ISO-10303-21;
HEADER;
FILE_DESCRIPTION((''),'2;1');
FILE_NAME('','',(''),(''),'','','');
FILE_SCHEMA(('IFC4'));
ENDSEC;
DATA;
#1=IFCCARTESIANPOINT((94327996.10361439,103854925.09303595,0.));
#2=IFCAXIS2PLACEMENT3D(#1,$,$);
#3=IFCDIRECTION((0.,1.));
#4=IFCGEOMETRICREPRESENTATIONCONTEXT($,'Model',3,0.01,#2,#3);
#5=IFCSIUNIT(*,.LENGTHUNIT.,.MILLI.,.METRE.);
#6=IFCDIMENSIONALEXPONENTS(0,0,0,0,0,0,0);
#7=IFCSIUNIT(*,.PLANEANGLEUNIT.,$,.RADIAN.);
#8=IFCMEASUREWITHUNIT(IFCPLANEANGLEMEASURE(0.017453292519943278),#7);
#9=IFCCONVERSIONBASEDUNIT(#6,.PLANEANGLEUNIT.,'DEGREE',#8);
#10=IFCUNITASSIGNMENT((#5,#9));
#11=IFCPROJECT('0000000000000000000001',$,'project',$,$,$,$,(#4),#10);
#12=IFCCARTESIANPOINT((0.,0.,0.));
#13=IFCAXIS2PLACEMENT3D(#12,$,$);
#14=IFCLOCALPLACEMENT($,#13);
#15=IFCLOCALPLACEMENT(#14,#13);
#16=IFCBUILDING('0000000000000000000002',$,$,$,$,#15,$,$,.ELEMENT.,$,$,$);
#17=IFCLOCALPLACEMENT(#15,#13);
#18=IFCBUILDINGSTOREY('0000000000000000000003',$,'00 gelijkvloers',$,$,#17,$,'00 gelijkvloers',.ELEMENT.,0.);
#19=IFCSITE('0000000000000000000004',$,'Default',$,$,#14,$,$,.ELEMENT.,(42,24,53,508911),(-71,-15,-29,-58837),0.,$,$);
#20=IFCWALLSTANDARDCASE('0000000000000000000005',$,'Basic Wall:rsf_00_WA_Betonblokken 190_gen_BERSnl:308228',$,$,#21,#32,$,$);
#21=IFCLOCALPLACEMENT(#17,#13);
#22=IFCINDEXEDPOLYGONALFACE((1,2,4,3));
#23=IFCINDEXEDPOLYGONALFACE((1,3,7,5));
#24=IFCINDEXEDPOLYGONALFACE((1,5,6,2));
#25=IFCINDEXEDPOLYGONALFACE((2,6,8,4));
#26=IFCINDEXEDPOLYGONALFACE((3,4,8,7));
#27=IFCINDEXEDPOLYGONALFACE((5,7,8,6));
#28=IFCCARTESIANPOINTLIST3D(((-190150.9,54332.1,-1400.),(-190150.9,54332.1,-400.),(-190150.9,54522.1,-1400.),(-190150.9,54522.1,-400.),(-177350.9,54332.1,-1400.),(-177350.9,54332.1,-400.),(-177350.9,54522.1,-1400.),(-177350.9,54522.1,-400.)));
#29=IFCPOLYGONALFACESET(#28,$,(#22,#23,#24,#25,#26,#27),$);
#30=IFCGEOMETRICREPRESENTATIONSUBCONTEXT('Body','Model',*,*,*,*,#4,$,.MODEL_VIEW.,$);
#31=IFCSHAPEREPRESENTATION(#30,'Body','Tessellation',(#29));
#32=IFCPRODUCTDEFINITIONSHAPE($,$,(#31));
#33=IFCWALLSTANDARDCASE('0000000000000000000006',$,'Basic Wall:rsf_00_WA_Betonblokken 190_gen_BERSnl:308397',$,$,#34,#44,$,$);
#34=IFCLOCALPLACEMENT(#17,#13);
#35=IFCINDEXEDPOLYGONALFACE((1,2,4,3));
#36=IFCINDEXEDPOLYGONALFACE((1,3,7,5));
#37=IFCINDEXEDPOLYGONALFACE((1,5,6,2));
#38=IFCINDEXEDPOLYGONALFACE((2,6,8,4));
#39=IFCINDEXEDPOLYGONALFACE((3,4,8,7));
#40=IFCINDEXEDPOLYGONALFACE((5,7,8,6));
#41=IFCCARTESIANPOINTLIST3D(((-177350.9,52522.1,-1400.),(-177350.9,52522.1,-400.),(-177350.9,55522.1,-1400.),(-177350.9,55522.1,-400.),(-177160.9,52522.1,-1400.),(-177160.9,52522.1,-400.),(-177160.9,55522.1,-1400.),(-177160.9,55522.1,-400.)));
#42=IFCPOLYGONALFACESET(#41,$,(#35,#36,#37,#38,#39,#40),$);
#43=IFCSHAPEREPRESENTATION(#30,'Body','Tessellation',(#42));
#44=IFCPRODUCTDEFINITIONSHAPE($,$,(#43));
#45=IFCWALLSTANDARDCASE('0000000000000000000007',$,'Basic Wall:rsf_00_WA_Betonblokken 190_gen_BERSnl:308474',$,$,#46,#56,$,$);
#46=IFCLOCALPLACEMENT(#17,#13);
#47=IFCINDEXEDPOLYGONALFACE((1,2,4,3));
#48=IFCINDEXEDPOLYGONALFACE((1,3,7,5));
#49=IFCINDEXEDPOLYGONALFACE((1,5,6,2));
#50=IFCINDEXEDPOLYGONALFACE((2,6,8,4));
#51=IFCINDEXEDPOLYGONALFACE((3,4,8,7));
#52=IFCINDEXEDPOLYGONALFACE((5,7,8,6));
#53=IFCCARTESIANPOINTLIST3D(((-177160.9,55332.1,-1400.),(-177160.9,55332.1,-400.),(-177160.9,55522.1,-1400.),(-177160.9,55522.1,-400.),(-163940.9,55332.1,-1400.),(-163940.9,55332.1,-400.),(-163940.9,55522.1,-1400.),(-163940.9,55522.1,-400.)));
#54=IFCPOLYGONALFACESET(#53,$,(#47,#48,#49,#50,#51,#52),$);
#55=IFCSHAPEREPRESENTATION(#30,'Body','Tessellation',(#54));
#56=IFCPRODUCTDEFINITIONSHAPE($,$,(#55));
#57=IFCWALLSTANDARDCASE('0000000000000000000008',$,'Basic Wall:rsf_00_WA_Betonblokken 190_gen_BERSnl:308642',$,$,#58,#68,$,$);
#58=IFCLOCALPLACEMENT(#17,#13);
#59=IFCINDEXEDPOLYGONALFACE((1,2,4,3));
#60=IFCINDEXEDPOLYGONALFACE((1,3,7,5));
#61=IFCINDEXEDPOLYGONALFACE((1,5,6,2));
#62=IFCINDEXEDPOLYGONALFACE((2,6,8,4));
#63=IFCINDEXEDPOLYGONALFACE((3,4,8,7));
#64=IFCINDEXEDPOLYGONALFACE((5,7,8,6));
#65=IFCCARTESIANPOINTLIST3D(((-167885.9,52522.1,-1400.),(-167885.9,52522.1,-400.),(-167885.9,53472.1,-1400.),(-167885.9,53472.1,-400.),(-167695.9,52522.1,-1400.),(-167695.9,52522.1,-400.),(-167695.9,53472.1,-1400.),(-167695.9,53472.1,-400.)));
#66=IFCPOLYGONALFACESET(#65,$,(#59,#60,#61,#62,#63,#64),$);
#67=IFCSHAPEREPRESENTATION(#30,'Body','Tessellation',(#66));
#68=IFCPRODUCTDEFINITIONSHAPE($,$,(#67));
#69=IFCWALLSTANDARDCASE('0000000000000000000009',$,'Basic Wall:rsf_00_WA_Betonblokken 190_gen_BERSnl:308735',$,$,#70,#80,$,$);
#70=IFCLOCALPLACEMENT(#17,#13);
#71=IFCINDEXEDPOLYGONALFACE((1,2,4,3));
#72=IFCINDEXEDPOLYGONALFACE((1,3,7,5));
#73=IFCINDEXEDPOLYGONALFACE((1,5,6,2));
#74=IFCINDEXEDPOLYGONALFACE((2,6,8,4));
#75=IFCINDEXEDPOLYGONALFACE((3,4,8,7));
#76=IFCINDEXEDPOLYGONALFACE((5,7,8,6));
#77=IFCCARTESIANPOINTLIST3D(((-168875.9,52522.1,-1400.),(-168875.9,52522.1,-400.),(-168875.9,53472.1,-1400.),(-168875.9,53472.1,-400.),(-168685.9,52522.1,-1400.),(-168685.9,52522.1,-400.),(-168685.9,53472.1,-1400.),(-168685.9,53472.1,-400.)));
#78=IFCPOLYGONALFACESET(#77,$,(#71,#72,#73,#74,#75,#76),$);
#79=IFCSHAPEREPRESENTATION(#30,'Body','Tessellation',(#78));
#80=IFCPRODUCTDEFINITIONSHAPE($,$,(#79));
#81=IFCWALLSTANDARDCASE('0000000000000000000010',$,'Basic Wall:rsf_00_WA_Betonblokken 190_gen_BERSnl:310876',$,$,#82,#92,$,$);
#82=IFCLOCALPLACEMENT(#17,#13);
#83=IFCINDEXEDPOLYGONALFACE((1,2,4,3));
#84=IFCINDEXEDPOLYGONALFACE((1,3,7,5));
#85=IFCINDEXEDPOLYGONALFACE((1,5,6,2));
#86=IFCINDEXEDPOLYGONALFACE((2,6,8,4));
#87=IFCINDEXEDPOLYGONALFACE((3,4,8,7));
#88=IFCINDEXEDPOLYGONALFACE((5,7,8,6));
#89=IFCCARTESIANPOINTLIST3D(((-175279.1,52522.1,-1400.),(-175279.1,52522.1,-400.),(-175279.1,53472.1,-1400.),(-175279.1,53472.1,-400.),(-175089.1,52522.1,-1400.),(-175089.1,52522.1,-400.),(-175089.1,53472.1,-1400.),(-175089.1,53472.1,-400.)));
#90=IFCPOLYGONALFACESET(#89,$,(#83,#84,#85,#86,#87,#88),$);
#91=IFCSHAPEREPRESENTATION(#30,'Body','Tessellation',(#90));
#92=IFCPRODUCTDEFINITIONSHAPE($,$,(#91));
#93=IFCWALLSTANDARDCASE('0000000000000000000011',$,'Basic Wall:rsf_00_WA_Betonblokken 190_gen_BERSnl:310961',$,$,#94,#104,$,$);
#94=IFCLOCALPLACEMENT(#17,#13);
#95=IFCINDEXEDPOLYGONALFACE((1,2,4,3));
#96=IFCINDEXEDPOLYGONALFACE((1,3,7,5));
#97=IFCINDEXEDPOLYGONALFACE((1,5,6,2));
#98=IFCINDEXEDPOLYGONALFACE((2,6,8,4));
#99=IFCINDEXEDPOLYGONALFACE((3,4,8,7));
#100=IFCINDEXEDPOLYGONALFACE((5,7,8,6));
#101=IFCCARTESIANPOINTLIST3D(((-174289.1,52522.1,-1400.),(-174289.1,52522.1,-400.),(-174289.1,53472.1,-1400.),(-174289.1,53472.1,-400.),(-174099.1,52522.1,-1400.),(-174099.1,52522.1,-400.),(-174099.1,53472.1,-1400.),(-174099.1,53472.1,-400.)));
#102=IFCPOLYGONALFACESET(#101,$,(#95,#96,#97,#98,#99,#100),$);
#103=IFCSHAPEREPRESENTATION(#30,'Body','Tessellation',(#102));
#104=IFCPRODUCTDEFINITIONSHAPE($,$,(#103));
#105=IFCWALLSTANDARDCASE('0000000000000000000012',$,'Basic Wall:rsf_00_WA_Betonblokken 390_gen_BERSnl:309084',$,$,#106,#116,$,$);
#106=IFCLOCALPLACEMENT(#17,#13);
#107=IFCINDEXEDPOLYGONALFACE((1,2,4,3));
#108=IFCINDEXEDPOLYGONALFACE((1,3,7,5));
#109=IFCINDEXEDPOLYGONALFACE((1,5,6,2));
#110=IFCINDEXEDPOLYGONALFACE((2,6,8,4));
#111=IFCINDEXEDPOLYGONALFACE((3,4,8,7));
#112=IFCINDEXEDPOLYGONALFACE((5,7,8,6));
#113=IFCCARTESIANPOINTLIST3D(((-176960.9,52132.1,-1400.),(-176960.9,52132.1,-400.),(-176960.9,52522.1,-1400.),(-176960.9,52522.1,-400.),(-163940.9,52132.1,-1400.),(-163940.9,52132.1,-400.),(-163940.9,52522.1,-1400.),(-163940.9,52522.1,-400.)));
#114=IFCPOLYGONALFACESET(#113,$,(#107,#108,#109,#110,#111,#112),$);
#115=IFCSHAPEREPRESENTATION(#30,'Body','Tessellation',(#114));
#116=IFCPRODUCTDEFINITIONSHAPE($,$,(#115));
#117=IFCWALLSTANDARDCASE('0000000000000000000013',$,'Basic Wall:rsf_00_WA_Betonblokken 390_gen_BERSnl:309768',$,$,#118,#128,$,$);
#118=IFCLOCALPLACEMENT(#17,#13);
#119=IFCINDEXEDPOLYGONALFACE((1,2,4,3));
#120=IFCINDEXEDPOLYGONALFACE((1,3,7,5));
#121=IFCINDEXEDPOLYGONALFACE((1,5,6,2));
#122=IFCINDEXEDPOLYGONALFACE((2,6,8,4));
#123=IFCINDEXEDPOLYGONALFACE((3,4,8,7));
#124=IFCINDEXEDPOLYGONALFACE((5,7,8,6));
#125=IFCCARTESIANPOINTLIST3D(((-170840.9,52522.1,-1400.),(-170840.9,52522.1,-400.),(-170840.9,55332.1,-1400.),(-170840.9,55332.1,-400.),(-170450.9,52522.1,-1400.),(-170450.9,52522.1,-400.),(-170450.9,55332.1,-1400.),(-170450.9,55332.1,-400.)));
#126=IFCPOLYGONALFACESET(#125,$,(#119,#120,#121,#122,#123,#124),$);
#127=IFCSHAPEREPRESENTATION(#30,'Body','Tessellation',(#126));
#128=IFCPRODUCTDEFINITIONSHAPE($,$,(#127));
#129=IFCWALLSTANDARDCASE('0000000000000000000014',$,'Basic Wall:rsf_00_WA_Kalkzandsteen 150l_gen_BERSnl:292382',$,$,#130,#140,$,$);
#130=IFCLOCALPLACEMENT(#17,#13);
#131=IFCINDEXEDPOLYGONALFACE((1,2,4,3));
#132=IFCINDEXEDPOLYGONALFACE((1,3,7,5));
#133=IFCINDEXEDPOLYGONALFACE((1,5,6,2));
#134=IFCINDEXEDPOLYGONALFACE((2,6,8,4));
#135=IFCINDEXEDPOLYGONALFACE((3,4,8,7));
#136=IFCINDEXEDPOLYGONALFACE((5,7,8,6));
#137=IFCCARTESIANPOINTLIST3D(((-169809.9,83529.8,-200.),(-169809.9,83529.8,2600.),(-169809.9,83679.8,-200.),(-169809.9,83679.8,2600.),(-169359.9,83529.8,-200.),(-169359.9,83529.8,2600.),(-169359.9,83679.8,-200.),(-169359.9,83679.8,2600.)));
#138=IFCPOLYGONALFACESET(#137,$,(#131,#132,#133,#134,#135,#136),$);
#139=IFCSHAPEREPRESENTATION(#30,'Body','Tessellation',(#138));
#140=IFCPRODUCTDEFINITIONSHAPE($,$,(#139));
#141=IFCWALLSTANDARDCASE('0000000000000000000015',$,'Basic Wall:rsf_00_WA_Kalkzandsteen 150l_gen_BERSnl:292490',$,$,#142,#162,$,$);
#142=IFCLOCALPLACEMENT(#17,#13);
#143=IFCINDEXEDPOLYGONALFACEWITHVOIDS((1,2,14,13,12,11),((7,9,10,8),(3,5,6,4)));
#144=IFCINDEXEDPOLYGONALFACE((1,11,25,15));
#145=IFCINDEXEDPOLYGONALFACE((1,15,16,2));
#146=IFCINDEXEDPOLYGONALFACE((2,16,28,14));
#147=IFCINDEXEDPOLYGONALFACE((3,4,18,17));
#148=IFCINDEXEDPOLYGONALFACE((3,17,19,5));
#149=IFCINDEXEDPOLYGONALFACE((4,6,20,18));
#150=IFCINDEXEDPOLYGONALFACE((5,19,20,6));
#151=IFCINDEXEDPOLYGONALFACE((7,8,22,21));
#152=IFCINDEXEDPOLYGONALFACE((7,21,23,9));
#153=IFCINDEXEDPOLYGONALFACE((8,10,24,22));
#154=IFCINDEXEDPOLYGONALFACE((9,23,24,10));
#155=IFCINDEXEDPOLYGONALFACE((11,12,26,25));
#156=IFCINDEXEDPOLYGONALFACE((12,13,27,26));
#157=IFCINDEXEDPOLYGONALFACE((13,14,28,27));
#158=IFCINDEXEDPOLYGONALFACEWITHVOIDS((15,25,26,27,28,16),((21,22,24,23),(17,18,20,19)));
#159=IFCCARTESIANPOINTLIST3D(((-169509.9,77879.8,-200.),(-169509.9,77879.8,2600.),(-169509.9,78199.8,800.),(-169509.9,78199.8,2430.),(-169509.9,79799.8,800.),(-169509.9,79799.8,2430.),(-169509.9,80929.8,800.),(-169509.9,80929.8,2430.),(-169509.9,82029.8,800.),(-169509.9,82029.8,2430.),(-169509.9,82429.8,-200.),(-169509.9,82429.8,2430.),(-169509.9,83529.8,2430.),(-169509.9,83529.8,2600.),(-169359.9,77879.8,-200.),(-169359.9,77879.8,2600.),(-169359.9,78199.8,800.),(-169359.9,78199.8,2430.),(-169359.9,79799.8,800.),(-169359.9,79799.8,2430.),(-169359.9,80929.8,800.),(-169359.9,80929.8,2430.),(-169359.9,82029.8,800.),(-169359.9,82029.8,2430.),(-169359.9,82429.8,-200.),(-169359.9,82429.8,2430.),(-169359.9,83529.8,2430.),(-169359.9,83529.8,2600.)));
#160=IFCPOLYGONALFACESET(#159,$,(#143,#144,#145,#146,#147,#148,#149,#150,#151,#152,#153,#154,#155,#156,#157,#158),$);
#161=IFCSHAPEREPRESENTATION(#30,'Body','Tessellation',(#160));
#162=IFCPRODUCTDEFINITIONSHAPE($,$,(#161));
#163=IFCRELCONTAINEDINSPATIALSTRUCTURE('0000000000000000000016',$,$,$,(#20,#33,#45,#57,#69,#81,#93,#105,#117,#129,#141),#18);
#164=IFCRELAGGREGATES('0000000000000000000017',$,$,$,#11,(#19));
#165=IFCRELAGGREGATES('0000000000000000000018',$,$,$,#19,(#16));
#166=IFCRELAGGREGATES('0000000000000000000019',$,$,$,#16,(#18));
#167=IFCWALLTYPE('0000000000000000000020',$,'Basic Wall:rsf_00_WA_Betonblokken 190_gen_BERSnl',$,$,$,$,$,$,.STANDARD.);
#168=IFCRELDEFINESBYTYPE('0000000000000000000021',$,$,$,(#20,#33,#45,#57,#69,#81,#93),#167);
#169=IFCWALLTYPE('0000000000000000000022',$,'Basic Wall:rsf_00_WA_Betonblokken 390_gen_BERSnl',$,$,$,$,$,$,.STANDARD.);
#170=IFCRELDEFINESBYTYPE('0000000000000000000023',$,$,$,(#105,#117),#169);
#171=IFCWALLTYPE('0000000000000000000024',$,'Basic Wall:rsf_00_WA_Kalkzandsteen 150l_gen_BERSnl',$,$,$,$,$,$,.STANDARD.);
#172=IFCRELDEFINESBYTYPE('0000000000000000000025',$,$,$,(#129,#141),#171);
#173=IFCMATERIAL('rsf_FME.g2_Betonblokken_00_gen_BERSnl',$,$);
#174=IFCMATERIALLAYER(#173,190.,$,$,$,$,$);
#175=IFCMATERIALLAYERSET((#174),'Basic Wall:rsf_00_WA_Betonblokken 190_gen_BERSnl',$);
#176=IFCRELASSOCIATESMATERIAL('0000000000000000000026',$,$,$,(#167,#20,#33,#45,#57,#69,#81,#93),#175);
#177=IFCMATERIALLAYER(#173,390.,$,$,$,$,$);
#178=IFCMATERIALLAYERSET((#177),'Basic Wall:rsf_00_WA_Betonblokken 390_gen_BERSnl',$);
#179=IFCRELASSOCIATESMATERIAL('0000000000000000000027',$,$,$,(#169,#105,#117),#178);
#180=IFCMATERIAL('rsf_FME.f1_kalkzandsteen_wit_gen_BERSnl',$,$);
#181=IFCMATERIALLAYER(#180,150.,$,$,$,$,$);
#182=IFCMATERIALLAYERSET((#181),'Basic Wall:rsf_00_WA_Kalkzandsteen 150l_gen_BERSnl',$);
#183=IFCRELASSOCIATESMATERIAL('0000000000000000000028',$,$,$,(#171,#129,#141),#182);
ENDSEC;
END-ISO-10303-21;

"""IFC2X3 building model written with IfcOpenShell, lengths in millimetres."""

from ifc_helpers import new_model, entity, si_unit, converted_unit, direction, frame, frame_2d, origin, place, context, subcontext, project, spatial, polyline, rectangle, extrude, clip, bounded_halfspace, material, layer, layer_set, layer_usage, type_object, element, save


model = new_model("IFC2X3")

# Units and contexts
model_context = context("Model", 3, precision=0.01, world=frame((94327996.10361439, 103854925.09303595, 0.0)), true_north=direction((0.0, 1.0)))
body_context = subcontext(model_context, "Body", "Model", "MODEL_VIEW")
ifc_project = project(units=[si_unit("LENGTHUNIT", "METRE", prefix="MILLI"), converted_unit("PLANEANGLEUNIT", "DEGREE", entity("IfcPlaneAngleMeasure", 0.017453292519943278), si_unit("PLANEANGLEUNIT", "RADIAN"), dimensions=[0, 0, 0, 0, 0, 0, 0])], contexts=[model_context])

# Site, building, storey
site_placement = place(None, origin())
site = spatial("IfcSite", under=ifc_project, at=site_placement, Name="Default", CompositionType="ELEMENT", RefLatitude=(42, 24, 53, 508911), RefLongitude=(-71, -15, -29, -58837), RefElevation=0.0)
building_placement = place(site_placement, origin())
building = spatial("IfcBuilding", under=site, at=building_placement, CompositionType="ELEMENT")
storey_placement = place(building_placement, origin())
storey = spatial("IfcBuildingStorey", under=building, at=storey_placement, Name="00 gelijkvloers", LongName="00 gelijkvloers", CompositionType="ELEMENT", Elevation=0.0)

# Walls
ifc_material_1 = material(Name="rsf_FME.g2_Betonblokken_00_gen_BERSnl")
ifc_layer_1 = layer(ifc_material_1, 190.0)
ifc_layer_set_1 = layer_set([ifc_layer_1], Name="Basic Wall:rsf_00_WA_Betonblokken 190_gen_BERSnl")
ifc_layer_usage_1 = layer_usage(ifc_layer_set_1, "AXIS2", "NEGATIVE", 95.0)
wall_type_1 = type_object("IfcWallType", Name="Basic Wall:rsf_00_WA_Betonblokken 190_gen_BERSnl", PredefinedType="STANDARD", material=ifc_layer_set_1)
wall_1_placement = place(storey_placement, frame((-190150.9, 54427.1, -1400.0)))
element("IfcWallStandardCase", 1, at=wall_1_placement, inside=storey, type_object=wall_type_1, material=ifc_layer_usage_1, Name="Basic Wall:rsf_00_WA_Betonblokken 190_gen_BERSnl:308228", context=body_context, shape_type="SweptSolid", body=[
    extrude(rectangle(XDim=12800.0, YDim=190.0, at=frame_2d((6400.0, 0.0), x_axis=(-1.0, 0.0))), origin(), (0.0, 0.0, 1.0), 1000.0),
])
ifc_layer_usage_2 = layer_usage(ifc_layer_set_1, "AXIS2", "POSITIVE", -95.0)
wall_2_placement = place(storey_placement, frame((-177255.9, 52522.1, -1400.0), z_axis=(0.0, 0.0, 1.0), x_axis=(0.0, 1.0, 0.0)))
element("IfcWallStandardCase", 2, at=wall_2_placement, inside=storey, type_object=wall_type_1, material=ifc_layer_usage_2, Name="Basic Wall:rsf_00_WA_Betonblokken 190_gen_BERSnl:308397", context=body_context, shape_type="SweptSolid", body=[
    extrude(rectangle(XDim=3000.0, YDim=190.0, at=frame_2d((1500.0, 0.0), x_axis=(-1.0, 0.0))), origin(), (0.0, 0.0, 1.0), 1000.0),
])
ifc_layer_usage_3 = layer_usage(ifc_layer_set_1, "AXIS2", "POSITIVE", -95.0)
wall_3_placement = place(storey_placement, frame((-177160.9, 55427.1, -1400.0)))
element("IfcWallStandardCase", 3, at=wall_3_placement, inside=storey, type_object=wall_type_1, material=ifc_layer_usage_3, Name="Basic Wall:rsf_00_WA_Betonblokken 190_gen_BERSnl:308474", context=body_context, shape_type="SweptSolid", body=[
    extrude(rectangle(XDim=13220.0, YDim=190.0, at=frame_2d((6610.0, 0.0), x_axis=(-1.0, 0.0))), origin(), (0.0, 0.0, 1.0), 1000.0),
])
ifc_layer_usage_4 = layer_usage(ifc_layer_set_1, "AXIS2", "POSITIVE", -95.0)
wall_4_placement = place(storey_placement, frame((-167790.9, 52522.1, -1400.0), z_axis=(0.0, 0.0, 1.0), x_axis=(0.0, 1.0, 0.0)))
element("IfcWallStandardCase", 4, at=wall_4_placement, inside=storey, type_object=wall_type_1, material=ifc_layer_usage_4, Name="Basic Wall:rsf_00_WA_Betonblokken 190_gen_BERSnl:308642", context=body_context, shape_type="SweptSolid", body=[
    extrude(rectangle(XDim=950.0, YDim=190.0, at=frame_2d((475.0, 0.0), x_axis=(-1.0, 0.0))), origin(), (0.0, 0.0, 1.0), 1000.0),
])
ifc_layer_usage_5 = layer_usage(ifc_layer_set_1, "AXIS2", "POSITIVE", -95.0)
wall_5_placement = place(storey_placement, frame((-168780.9, 52522.1, -1400.0), z_axis=(0.0, 0.0, 1.0), x_axis=(0.0, 1.0, 0.0)))
element("IfcWallStandardCase", 5, at=wall_5_placement, inside=storey, type_object=wall_type_1, material=ifc_layer_usage_5, Name="Basic Wall:rsf_00_WA_Betonblokken 190_gen_BERSnl:308735", context=body_context, shape_type="SweptSolid", body=[
    extrude(rectangle(XDim=950.0, YDim=190.0, at=frame_2d((475.0, 0.0), x_axis=(-1.0, 0.0))), origin(), (0.0, 0.0, 1.0), 1000.0),
])
ifc_layer_usage_6 = layer_usage(ifc_layer_set_1, "AXIS2", "NEGATIVE", 95.0)
wall_6_placement = place(storey_placement, frame((-175184.1, 52522.1, -1400.0), z_axis=(0.0, 0.0, 1.0), x_axis=(0.0, 1.0, 0.0)))
element("IfcWallStandardCase", 6, at=wall_6_placement, inside=storey, type_object=wall_type_1, material=ifc_layer_usage_6, Name="Basic Wall:rsf_00_WA_Betonblokken 190_gen_BERSnl:310876", context=body_context, shape_type="SweptSolid", body=[
    extrude(rectangle(XDim=950.0, YDim=190.0, at=frame_2d((475.0, 0.0), x_axis=(-1.0, 0.0))), origin(), (0.0, 0.0, 1.0), 1000.0),
])
ifc_layer_usage_7 = layer_usage(ifc_layer_set_1, "AXIS2", "NEGATIVE", 95.0)
wall_7_placement = place(storey_placement, frame((-174194.1, 52522.1, -1400.0), z_axis=(0.0, 0.0, 1.0), x_axis=(0.0, 1.0, 0.0)))
element("IfcWallStandardCase", 7, at=wall_7_placement, inside=storey, type_object=wall_type_1, material=ifc_layer_usage_7, Name="Basic Wall:rsf_00_WA_Betonblokken 190_gen_BERSnl:310961", context=body_context, shape_type="SweptSolid", body=[
    extrude(rectangle(XDim=950.0, YDim=190.0, at=frame_2d((475.0, 0.0), x_axis=(-1.0, 0.0))), origin(), (0.0, 0.0, 1.0), 1000.0),
])
ifc_layer_2 = layer(ifc_material_1, 390.0)
ifc_layer_set_2 = layer_set([ifc_layer_2], Name="Basic Wall:rsf_00_WA_Betonblokken 390_gen_BERSnl")
ifc_layer_usage_8 = layer_usage(ifc_layer_set_2, "AXIS2", "NEGATIVE", 195.0)
wall_type_2 = type_object("IfcWallType", Name="Basic Wall:rsf_00_WA_Betonblokken 390_gen_BERSnl", PredefinedType="STANDARD", material=ifc_layer_set_2)
wall_8_placement = place(storey_placement, frame((-176960.9, 52327.1, -1400.0)))
element("IfcWallStandardCase", 8, at=wall_8_placement, inside=storey, type_object=wall_type_2, material=ifc_layer_usage_8, Name="Basic Wall:rsf_00_WA_Betonblokken 390_gen_BERSnl:309084", context=body_context, shape_type="SweptSolid", body=[
    extrude(rectangle(XDim=13020.0, YDim=390.0, at=frame_2d((6510.0, 0.0), x_axis=(-1.0, 0.0))), origin(), (0.0, 0.0, 1.0), 1000.0),
])
ifc_layer_usage_9 = layer_usage(ifc_layer_set_2, "AXIS2", "POSITIVE", -195.0)
wall_9_placement = place(storey_placement, frame((-170645.9, 52522.1, -1400.0), z_axis=(0.0, 0.0, 1.0), x_axis=(0.0, 1.0, 0.0)))
element("IfcWallStandardCase", 9, at=wall_9_placement, inside=storey, type_object=wall_type_2, material=ifc_layer_usage_9, Name="Basic Wall:rsf_00_WA_Betonblokken 390_gen_BERSnl:309768", context=body_context, shape_type="SweptSolid", body=[
    extrude(rectangle(XDim=2810.0, YDim=390.0, at=frame_2d((1405.0, 0.0), x_axis=(-1.0, 0.0))), origin(), (0.0, 0.0, 1.0), 1000.0),
])
ifc_material_2 = material(Name="rsf_FME.f1_kalkzandsteen_wit_gen_BERSnl")
ifc_layer_3 = layer(ifc_material_2, 150.0)
ifc_layer_set_3 = layer_set([ifc_layer_3], Name="Basic Wall:rsf_00_WA_Kalkzandsteen 150l_gen_BERSnl")
ifc_layer_usage_10 = layer_usage(ifc_layer_set_3, "AXIS2", "POSITIVE", -75.0)
wall_type_3 = type_object("IfcWallType", Name="Basic Wall:rsf_00_WA_Kalkzandsteen 150l_gen_BERSnl", PredefinedType="STANDARD", material=ifc_layer_set_3)
wall_10_placement = place(storey_placement, frame((-169809.9, 83604.8, -200.0)))
element("IfcWallStandardCase", 10, at=wall_10_placement, inside=storey, type_object=wall_type_3, material=ifc_layer_usage_10, Name="Basic Wall:rsf_00_WA_Kalkzandsteen 150l_gen_BERSnl:292382", context=body_context, shape_type="Clipping", body=[
    clip(extrude(rectangle(XDim=450.0, YDim=150.0, at=frame_2d((225.0, 0.0), x_axis=(-1.0, 0.0))), origin(), (0.0, 0.0, 1.0), 2800.0), bounded_halfspace(frame((0.0, -75.0, 2800.0), z_axis=(0.0, 0.0, -1.0), x_axis=(0.0, 1.0, 0.0)), True, frame((0.0, -75.0, 2800.0)), polyline([(0.0, 0.0), (300.0, 0.0), (450.0, 0.0), (450.0, 150.0), (0.0, 150.0), (0.0, 0.0)]))),
])

# Wall, openings
ifc_layer_usage_11 = layer_usage(ifc_layer_set_3, "AXIS2", "POSITIVE", -75.0)
wall_11_placement = place(storey_placement, frame((-169434.9, 83529.8, -200.0), z_axis=(0.0, 0.0, 1.0), x_axis=(0.0, -1.0, 0.0)))
wall_11 = element("IfcWallStandardCase", 11, at=wall_11_placement, inside=storey, type_object=wall_type_3, material=ifc_layer_usage_11, Name="Basic Wall:rsf_00_WA_Kalkzandsteen 150l_gen_BERSnl:292490", context=body_context, shape_type="Clipping", body=[
    clip(extrude(rectangle(XDim=5650.0, YDim=150.0, at=frame_2d((2825.0, 0.0), x_axis=(-1.0, 0.0))), origin(), (0.0, 0.0, 1.0), 2800.0), bounded_halfspace(frame((0.0, -75.0, 2800.0), z_axis=(0.0, 0.0, -1.0), x_axis=(-1.0, 0.0, 0.0)), True, frame((0.0, -75.0, 2800.0)), polyline([(0.0, 0.0), (5500.0, 0.0), (5650.0, 0.0), (5650.0, 150.0), (0.0, 150.0), (0.0, 0.0)]))),
])
opening_1_placement = place(wall_11_placement, frame((83529.8, 169434.9, 200.0), z_axis=(0.0, 0.0, 1.0), x_axis=(0.0, 1.0, 0.0)))
element("IfcOpeningElement", 12, at=opening_1_placement, cuts=wall_11, ObjectType="Opening", context=body_context, shape_type="SweptSolid", body=[
    extrude(rectangle(XDim=2630.0, YDim=1100.0, at=frame_2d((0.0, 0.0), x_axis=(0.0, 1.0))), frame((-171033.9, 82979.8, 1115.0), z_axis=(1.0, 0.0, 0.0), x_axis=(0.0, 1.0, 0.0)), (0.0, 0.0, 1.0), 3048.0),
])
opening_2_placement = place(wall_11_placement, frame((83529.8, 169434.9, 200.0), z_axis=(0.0, 0.0, 1.0), x_axis=(0.0, 1.0, 0.0)))
element("IfcOpeningElement", 13, at=opening_2_placement, cuts=wall_11, ObjectType="Opening", context=body_context, shape_type="SweptSolid", body=[
    extrude(rectangle(XDim=1630.0, YDim=1100.0, at=frame_2d((0.0, 0.0), x_axis=(1.0, 0.0))), frame((-170883.9, 81479.8, 1615.0), z_axis=(1.0, 0.0, 0.0), x_axis=(0.0, 0.0, 1.0)), (0.0, 0.0, 1.0), 3048.0),
])
opening_3_placement = place(wall_11_placement, frame((83529.8, 169434.9, 200.0), z_axis=(0.0, 0.0, 1.0), x_axis=(0.0, 1.0, 0.0)))
element("IfcOpeningElement", 14, at=opening_3_placement, cuts=wall_11, ObjectType="Opening", context=body_context, shape_type="SweptSolid", body=[
    extrude(rectangle(XDim=1630.0, YDim=1600.0, at=frame_2d((0.0, 0.0), x_axis=(0.0, 1.0))), frame((-171033.9, 78999.8, 1615.0), z_axis=(1.0, 0.0, 0.0), x_axis=(0.0, 1.0, 0.0)), (0.0, 0.0, 1.0), 3048.0),
])

save(model, "model.ifc")
